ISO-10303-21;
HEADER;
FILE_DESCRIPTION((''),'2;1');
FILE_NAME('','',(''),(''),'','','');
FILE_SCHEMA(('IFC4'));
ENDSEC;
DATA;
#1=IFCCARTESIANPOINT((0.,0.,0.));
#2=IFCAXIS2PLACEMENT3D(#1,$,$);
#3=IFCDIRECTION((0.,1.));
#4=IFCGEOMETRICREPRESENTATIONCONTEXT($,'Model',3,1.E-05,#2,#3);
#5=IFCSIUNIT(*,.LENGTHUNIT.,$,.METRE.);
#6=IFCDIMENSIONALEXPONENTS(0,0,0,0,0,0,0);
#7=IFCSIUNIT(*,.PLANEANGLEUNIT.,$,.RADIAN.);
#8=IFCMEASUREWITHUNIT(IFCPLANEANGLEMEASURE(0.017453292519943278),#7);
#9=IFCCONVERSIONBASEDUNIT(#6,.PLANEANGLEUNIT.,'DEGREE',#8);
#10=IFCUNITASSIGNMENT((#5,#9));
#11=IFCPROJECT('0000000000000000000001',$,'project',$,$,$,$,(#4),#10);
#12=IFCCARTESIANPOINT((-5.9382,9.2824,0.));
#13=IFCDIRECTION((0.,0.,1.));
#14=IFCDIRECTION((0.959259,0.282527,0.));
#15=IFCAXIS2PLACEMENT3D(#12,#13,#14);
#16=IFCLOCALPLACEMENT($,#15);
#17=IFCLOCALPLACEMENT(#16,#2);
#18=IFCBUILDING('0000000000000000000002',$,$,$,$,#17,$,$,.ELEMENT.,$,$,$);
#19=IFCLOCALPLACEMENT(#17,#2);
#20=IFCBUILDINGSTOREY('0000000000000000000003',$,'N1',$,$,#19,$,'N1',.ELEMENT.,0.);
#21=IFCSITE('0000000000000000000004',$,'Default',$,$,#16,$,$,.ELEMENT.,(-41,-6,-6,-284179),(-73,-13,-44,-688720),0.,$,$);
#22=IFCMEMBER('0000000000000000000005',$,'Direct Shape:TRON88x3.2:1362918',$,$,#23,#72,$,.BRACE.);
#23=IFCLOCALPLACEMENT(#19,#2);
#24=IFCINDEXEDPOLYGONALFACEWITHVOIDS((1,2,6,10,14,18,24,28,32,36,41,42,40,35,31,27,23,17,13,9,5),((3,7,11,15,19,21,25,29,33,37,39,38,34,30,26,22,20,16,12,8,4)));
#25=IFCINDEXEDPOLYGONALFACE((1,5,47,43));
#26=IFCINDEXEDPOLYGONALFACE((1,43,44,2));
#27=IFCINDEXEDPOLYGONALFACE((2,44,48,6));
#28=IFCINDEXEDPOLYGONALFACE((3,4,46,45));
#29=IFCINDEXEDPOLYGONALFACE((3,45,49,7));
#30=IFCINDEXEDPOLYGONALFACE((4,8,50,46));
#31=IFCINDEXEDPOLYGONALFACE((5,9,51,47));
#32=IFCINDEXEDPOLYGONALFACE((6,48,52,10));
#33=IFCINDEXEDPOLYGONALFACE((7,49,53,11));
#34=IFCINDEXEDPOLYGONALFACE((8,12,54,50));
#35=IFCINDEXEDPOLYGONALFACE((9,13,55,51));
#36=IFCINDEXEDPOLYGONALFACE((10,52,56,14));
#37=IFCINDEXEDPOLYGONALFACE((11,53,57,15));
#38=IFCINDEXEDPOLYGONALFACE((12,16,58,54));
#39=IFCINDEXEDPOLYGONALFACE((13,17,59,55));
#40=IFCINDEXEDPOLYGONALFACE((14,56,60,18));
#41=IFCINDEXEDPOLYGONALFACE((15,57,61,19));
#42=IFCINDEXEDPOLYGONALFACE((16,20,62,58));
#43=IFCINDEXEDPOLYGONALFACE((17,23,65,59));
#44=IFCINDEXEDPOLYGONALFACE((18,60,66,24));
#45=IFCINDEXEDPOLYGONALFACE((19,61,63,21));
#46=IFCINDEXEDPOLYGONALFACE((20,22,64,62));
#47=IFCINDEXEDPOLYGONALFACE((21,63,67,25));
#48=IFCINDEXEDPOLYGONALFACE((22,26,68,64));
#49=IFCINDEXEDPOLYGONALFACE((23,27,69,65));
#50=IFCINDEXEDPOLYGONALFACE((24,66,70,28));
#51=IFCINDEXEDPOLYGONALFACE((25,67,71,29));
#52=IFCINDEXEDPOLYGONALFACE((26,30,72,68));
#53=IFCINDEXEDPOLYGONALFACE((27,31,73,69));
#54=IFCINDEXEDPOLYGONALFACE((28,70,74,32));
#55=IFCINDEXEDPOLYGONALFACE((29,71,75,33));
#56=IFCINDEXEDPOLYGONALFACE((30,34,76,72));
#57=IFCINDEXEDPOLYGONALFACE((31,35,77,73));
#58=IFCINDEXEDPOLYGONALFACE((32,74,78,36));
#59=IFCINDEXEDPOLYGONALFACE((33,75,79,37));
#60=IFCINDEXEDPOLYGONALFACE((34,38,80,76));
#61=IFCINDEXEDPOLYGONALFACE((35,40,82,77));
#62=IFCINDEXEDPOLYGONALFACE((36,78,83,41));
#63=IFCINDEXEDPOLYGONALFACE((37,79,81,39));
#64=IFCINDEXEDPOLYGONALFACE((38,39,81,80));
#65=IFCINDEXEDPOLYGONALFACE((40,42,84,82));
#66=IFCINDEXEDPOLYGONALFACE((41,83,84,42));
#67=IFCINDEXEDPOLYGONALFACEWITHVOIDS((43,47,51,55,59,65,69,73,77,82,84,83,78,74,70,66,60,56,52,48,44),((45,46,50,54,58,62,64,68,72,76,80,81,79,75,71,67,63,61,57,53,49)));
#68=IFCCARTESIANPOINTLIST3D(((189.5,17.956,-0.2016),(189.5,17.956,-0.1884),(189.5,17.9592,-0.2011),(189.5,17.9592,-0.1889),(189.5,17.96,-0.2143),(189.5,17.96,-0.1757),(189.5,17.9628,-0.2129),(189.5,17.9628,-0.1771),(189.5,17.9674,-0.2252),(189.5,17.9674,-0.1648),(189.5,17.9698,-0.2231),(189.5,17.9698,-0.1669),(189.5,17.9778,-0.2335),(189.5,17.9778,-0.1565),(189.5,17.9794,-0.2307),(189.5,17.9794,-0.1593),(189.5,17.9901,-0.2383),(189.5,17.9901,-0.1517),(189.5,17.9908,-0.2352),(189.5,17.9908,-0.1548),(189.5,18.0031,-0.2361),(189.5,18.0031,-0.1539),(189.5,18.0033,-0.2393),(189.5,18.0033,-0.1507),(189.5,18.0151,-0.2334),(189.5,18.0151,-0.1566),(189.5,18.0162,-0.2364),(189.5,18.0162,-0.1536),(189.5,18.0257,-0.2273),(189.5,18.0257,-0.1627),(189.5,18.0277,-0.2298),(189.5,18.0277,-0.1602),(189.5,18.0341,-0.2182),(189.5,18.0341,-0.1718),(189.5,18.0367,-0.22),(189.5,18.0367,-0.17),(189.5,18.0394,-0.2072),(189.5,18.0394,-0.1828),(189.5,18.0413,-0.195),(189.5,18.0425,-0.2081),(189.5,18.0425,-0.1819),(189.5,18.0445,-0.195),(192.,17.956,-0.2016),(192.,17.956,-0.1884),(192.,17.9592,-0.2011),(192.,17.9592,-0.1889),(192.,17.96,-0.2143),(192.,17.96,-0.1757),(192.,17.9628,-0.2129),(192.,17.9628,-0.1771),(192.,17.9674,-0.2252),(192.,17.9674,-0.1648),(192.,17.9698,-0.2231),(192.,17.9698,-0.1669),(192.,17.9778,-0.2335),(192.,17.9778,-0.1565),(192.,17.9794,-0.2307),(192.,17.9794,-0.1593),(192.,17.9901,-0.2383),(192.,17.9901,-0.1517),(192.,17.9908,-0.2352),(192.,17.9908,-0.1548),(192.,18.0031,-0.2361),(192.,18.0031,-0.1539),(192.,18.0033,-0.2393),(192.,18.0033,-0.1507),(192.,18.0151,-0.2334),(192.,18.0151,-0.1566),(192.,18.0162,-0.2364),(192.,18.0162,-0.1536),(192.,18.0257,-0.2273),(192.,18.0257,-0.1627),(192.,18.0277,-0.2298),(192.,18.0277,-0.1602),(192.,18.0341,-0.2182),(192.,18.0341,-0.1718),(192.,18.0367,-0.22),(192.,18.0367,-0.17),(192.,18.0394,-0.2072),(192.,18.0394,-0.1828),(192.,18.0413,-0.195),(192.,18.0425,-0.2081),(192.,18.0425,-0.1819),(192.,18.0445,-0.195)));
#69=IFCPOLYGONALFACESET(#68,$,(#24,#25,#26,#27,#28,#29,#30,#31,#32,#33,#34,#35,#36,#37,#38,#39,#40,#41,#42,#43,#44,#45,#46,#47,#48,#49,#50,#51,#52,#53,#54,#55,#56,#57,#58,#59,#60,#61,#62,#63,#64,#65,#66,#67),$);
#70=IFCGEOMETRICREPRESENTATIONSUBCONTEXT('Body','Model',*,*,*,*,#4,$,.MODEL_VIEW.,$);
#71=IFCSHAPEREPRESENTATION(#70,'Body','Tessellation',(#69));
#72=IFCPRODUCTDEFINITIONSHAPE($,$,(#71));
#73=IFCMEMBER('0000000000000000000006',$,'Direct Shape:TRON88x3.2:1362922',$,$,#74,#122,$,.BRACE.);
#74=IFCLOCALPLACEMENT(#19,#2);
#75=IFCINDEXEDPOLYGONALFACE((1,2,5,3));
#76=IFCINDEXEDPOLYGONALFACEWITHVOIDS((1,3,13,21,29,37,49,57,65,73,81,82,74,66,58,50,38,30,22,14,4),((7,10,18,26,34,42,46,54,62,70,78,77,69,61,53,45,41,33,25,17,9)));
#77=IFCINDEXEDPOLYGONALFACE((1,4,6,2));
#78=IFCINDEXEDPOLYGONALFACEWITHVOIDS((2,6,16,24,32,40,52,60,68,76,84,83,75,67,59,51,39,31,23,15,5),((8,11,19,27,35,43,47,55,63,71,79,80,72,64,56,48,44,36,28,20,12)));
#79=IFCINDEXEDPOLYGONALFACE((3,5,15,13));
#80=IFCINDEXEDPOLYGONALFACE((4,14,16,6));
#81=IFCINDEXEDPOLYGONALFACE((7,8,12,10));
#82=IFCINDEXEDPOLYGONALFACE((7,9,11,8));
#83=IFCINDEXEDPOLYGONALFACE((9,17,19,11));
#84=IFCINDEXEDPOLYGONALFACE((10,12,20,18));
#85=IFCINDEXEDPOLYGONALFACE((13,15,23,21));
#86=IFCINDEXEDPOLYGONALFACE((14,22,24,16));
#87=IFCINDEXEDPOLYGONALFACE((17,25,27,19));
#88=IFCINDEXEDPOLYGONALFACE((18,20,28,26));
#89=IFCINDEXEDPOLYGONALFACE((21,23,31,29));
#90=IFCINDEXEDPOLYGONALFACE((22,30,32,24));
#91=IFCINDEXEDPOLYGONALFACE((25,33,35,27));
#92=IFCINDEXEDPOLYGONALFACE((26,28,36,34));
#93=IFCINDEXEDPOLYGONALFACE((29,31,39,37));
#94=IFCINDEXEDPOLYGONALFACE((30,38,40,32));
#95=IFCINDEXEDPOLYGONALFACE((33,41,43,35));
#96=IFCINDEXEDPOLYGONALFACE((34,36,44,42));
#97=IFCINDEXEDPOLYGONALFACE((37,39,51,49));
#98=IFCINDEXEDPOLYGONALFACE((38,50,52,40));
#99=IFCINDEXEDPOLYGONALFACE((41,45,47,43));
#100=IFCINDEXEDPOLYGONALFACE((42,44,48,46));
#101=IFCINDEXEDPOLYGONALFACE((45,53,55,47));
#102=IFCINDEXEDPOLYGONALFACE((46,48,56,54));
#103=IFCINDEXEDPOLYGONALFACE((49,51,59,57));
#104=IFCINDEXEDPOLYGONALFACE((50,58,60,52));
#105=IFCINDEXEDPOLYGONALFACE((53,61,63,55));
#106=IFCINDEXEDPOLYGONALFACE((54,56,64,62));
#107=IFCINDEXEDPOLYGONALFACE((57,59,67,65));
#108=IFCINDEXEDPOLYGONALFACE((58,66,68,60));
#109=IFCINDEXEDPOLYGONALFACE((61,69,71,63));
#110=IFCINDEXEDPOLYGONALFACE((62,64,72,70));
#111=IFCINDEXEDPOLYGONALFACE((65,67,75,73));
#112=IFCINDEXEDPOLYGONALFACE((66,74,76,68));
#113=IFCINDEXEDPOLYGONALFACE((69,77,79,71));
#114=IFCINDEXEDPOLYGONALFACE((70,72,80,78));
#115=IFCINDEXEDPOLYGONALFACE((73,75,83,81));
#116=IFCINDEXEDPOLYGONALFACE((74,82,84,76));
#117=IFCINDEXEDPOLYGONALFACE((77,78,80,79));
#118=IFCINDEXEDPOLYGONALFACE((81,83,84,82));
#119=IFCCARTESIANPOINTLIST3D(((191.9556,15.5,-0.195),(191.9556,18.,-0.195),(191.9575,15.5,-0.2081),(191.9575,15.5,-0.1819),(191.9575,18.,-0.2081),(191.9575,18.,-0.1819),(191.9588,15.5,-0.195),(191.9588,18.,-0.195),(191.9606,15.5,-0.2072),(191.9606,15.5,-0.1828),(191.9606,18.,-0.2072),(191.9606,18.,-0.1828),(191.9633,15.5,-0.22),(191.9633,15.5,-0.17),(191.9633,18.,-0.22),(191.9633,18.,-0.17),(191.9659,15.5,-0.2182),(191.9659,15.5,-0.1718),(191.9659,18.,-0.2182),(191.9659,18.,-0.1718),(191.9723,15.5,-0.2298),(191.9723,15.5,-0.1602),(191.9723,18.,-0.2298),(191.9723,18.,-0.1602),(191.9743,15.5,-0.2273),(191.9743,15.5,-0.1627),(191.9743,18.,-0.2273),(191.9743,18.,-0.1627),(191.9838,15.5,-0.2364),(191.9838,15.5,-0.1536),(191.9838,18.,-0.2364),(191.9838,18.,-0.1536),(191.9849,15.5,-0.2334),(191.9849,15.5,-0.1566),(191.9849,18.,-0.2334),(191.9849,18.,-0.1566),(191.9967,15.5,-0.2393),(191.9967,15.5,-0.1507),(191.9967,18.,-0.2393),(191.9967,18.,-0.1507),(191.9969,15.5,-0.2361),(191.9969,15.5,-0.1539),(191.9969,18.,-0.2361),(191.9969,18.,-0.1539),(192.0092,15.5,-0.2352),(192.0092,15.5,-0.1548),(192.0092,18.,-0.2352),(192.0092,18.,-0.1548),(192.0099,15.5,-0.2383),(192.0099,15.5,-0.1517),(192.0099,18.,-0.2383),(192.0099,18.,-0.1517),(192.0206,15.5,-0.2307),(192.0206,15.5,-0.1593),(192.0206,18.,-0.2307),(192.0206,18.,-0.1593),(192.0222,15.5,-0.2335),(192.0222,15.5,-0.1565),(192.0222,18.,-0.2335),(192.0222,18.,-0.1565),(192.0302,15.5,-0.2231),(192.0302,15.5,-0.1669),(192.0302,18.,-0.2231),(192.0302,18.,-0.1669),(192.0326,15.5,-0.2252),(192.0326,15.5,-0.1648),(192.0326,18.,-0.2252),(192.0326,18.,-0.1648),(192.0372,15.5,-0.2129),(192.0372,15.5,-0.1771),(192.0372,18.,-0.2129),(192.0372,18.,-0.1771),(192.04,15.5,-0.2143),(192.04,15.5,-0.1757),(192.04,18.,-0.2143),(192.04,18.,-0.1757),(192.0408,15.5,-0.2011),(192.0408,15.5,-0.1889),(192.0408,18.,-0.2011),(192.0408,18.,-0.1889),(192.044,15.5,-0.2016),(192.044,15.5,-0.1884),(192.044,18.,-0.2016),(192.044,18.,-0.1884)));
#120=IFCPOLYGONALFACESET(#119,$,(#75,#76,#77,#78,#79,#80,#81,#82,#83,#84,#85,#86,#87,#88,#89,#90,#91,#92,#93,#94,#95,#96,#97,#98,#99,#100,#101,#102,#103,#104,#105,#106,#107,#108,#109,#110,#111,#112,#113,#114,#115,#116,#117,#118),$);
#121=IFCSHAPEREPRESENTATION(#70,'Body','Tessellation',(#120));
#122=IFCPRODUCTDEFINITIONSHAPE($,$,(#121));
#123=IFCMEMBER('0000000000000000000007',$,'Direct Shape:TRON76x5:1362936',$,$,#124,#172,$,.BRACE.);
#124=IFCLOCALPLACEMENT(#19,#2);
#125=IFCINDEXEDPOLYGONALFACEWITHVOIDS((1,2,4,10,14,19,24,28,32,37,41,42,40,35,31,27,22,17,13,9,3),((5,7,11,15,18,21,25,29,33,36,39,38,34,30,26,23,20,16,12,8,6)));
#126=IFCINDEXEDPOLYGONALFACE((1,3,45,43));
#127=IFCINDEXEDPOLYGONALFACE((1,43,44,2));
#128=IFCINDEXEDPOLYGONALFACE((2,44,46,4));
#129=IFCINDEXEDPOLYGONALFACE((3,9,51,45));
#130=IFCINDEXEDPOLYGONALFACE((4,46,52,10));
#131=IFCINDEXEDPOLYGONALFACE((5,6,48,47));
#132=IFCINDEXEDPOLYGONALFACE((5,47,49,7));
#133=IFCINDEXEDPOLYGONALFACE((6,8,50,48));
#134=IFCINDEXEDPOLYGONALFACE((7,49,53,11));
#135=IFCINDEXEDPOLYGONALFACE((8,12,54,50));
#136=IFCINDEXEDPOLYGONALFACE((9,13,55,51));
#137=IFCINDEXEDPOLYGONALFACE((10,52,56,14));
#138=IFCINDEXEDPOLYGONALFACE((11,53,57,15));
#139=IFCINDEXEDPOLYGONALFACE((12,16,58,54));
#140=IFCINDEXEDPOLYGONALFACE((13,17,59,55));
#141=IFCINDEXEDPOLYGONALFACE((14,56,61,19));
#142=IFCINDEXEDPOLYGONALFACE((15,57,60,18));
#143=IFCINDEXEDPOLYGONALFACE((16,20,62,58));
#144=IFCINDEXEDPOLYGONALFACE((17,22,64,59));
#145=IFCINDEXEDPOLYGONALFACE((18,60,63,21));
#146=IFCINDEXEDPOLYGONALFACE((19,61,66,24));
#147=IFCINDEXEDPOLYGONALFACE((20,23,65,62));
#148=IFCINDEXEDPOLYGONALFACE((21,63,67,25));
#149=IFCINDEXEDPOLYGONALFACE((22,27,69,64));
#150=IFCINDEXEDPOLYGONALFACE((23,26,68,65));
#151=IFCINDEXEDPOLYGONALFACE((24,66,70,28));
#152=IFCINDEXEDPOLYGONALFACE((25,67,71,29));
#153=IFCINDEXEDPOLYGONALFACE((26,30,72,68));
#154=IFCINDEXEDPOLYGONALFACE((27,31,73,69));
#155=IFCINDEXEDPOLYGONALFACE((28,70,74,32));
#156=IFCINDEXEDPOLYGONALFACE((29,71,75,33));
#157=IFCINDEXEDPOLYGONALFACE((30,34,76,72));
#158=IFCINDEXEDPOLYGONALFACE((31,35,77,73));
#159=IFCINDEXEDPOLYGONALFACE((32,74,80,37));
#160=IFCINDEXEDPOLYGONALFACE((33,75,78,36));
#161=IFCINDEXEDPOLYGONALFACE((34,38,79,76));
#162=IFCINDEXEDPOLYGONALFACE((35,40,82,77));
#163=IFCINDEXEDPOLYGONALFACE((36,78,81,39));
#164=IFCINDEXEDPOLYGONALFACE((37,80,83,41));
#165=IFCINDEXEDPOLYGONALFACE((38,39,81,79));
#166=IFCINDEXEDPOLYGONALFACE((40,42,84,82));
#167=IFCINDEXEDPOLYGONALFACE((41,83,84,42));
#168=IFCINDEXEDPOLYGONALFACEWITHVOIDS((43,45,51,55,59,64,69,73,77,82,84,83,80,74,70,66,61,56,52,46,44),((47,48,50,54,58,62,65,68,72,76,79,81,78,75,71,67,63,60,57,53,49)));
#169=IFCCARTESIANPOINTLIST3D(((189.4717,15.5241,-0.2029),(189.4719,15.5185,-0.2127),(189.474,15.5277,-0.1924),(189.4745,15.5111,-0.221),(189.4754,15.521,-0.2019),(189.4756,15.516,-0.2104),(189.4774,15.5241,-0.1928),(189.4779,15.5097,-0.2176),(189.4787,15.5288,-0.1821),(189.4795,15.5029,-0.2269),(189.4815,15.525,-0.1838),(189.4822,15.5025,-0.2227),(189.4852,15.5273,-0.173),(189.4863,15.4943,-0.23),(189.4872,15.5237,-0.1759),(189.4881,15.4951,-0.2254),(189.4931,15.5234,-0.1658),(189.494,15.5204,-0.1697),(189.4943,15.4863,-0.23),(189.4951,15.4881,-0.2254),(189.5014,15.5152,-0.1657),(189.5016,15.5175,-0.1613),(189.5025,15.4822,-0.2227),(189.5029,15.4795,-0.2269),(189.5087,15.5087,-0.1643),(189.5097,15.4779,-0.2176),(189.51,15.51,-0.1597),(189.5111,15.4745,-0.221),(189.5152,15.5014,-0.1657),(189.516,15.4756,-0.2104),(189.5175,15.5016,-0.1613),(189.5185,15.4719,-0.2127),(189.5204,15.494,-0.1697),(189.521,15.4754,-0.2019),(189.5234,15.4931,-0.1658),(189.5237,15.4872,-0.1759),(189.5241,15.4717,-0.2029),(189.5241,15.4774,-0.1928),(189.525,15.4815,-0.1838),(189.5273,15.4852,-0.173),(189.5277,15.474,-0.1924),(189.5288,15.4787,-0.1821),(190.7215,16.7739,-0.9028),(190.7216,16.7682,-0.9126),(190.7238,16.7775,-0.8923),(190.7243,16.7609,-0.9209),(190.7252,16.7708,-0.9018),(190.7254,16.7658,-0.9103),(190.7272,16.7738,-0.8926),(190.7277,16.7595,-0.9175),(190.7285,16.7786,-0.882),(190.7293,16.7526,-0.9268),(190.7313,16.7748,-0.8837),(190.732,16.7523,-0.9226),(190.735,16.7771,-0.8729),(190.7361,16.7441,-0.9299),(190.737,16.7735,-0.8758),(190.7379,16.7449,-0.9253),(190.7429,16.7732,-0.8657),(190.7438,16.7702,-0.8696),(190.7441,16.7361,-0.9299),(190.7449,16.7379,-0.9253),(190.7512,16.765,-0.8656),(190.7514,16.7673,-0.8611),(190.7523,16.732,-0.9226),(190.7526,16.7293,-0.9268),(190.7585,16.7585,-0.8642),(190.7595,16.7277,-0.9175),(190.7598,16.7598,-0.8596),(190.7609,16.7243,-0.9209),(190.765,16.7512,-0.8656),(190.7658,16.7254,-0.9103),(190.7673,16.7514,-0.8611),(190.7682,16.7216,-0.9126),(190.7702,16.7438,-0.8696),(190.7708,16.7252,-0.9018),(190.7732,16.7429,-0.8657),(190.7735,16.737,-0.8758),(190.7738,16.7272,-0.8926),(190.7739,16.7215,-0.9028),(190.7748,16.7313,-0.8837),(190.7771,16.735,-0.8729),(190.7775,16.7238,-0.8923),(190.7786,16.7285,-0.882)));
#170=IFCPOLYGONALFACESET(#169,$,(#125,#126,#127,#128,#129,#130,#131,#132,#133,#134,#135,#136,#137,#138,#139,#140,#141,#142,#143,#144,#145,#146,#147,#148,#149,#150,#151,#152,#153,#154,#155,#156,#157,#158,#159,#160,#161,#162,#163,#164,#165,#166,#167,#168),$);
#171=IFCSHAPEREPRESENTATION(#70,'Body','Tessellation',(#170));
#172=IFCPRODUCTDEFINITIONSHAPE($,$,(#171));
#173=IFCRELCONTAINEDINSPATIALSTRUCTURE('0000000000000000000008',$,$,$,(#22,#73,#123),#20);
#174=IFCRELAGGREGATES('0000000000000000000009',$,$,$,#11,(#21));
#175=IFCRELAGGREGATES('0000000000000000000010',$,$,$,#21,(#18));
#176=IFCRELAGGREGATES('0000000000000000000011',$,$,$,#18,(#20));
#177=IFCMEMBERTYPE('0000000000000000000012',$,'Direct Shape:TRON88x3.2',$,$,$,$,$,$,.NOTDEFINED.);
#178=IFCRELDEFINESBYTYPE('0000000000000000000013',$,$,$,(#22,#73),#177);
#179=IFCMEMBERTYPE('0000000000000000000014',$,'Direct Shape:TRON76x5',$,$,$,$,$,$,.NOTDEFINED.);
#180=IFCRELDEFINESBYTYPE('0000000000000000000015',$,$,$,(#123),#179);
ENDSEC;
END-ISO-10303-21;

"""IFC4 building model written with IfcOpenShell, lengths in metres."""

from ifc_helpers import new_model, entity, si_unit, converted_unit, direction, frame, frame_2d, origin, place, context, subcontext, project, spatial, hollow_circle, extrude, type_object, element, save


model = new_model("IFC4")

# Units and contexts
model_context = context("Model", 3, precision=1e-05, world=origin(), true_north=direction((0.0, 1.0)))
body_context = subcontext(model_context, "Body", "Model", "MODEL_VIEW")
ifc_project = project(units=[si_unit("LENGTHUNIT", "METRE"), converted_unit("PLANEANGLEUNIT", "DEGREE", entity("IfcPlaneAngleMeasure", 0.017453292519943278), si_unit("PLANEANGLEUNIT", "RADIAN"), dimensions=[0, 0, 0, 0, 0, 0, 0])], contexts=[model_context])

# Site, building, storey
site_placement = place(None, frame((-5.9382, 9.2824, 0.0), z_axis=(0.0, 0.0, 1.0), x_axis=(0.959259, 0.282527, 0.0)))
site = spatial("IfcSite", under=ifc_project, at=site_placement, Name="Default", CompositionType="ELEMENT", RefLatitude=(-41, -6, -6, -284179), RefLongitude=(-73, -13, -44, -688720), RefElevation=0.0)
building_placement = place(site_placement, origin())
building = spatial("IfcBuilding", under=site, at=building_placement, CompositionType="ELEMENT")
storey_placement = place(building_placement, origin())
storey = spatial("IfcBuildingStorey", under=building, at=storey_placement, Name="N1", LongName="N1", CompositionType="ELEMENT", Elevation=0.0)

# Members
member_type_1 = type_object("IfcMemberType", Name="Direct Shape:TRON88x3.2", PredefinedType="NOTDEFINED")
member_1_placement = place(storey_placement, origin())
element("IfcMember", 1, at=member_1_placement, inside=storey, type_object=member_type_1, Name="Direct Shape:TRON88x3.2:1362918", PredefinedType="BRACE", context=body_context, shape_type="SweptSolid", body=[
    extrude(hollow_circle(Radius=0.0445, WallThickness=0.0032, at=frame_2d((0.0, 0.0), x_axis=(1.0, 0.0))), frame((189.5, 18.0, -0.195), z_axis=(1.0, 0.0, 0.0), x_axis=(0.0, 1.0, 0.0)), (0.0, 0.0, 1.0), 2.5),
])
member_2_placement = place(storey_placement, origin())
element("IfcMember", 2, at=member_2_placement, inside=storey, type_object=member_type_1, Name="Direct Shape:TRON88x3.2:1362922", PredefinedType="BRACE", context=body_context, shape_type="SweptSolid", body=[
    extrude(hollow_circle(Radius=0.0445, WallThickness=0.0032, at=frame_2d((0.0, 0.0), x_axis=(1.0, 0.0))), frame((192.0, 15.5, -0.195), z_axis=(0.0, 1.0, 0.0), x_axis=(-1.0, 0.0, 0.0)), (0.0, 0.0, 1.0), 2.5),
])
member_type_2 = type_object("IfcMemberType", Name="Direct Shape:TRON76x5", PredefinedType="NOTDEFINED")
member_3_placement = place(storey_placement, origin())
element("IfcMember", 3, at=member_3_placement, inside=storey, type_object=member_type_2, Name="Direct Shape:TRON76x5:1362936", PredefinedType="BRACE", context=body_context, shape_type="SweptSolid", body=[
    extrude(hollow_circle(Radius=0.0381, WallThickness=0.005, at=frame_2d((0.0, 0.0), x_axis=(1.0, 0.0))), frame((189.5001, 15.5001, -0.1951), z_axis=(0.65744, 0.65744, -0.368166), x_axis=(0.260333, 0.260333, 0.92976)), (0.0, 0.0, 1.0), 1.901),
])

save(model, "model.ifc")
